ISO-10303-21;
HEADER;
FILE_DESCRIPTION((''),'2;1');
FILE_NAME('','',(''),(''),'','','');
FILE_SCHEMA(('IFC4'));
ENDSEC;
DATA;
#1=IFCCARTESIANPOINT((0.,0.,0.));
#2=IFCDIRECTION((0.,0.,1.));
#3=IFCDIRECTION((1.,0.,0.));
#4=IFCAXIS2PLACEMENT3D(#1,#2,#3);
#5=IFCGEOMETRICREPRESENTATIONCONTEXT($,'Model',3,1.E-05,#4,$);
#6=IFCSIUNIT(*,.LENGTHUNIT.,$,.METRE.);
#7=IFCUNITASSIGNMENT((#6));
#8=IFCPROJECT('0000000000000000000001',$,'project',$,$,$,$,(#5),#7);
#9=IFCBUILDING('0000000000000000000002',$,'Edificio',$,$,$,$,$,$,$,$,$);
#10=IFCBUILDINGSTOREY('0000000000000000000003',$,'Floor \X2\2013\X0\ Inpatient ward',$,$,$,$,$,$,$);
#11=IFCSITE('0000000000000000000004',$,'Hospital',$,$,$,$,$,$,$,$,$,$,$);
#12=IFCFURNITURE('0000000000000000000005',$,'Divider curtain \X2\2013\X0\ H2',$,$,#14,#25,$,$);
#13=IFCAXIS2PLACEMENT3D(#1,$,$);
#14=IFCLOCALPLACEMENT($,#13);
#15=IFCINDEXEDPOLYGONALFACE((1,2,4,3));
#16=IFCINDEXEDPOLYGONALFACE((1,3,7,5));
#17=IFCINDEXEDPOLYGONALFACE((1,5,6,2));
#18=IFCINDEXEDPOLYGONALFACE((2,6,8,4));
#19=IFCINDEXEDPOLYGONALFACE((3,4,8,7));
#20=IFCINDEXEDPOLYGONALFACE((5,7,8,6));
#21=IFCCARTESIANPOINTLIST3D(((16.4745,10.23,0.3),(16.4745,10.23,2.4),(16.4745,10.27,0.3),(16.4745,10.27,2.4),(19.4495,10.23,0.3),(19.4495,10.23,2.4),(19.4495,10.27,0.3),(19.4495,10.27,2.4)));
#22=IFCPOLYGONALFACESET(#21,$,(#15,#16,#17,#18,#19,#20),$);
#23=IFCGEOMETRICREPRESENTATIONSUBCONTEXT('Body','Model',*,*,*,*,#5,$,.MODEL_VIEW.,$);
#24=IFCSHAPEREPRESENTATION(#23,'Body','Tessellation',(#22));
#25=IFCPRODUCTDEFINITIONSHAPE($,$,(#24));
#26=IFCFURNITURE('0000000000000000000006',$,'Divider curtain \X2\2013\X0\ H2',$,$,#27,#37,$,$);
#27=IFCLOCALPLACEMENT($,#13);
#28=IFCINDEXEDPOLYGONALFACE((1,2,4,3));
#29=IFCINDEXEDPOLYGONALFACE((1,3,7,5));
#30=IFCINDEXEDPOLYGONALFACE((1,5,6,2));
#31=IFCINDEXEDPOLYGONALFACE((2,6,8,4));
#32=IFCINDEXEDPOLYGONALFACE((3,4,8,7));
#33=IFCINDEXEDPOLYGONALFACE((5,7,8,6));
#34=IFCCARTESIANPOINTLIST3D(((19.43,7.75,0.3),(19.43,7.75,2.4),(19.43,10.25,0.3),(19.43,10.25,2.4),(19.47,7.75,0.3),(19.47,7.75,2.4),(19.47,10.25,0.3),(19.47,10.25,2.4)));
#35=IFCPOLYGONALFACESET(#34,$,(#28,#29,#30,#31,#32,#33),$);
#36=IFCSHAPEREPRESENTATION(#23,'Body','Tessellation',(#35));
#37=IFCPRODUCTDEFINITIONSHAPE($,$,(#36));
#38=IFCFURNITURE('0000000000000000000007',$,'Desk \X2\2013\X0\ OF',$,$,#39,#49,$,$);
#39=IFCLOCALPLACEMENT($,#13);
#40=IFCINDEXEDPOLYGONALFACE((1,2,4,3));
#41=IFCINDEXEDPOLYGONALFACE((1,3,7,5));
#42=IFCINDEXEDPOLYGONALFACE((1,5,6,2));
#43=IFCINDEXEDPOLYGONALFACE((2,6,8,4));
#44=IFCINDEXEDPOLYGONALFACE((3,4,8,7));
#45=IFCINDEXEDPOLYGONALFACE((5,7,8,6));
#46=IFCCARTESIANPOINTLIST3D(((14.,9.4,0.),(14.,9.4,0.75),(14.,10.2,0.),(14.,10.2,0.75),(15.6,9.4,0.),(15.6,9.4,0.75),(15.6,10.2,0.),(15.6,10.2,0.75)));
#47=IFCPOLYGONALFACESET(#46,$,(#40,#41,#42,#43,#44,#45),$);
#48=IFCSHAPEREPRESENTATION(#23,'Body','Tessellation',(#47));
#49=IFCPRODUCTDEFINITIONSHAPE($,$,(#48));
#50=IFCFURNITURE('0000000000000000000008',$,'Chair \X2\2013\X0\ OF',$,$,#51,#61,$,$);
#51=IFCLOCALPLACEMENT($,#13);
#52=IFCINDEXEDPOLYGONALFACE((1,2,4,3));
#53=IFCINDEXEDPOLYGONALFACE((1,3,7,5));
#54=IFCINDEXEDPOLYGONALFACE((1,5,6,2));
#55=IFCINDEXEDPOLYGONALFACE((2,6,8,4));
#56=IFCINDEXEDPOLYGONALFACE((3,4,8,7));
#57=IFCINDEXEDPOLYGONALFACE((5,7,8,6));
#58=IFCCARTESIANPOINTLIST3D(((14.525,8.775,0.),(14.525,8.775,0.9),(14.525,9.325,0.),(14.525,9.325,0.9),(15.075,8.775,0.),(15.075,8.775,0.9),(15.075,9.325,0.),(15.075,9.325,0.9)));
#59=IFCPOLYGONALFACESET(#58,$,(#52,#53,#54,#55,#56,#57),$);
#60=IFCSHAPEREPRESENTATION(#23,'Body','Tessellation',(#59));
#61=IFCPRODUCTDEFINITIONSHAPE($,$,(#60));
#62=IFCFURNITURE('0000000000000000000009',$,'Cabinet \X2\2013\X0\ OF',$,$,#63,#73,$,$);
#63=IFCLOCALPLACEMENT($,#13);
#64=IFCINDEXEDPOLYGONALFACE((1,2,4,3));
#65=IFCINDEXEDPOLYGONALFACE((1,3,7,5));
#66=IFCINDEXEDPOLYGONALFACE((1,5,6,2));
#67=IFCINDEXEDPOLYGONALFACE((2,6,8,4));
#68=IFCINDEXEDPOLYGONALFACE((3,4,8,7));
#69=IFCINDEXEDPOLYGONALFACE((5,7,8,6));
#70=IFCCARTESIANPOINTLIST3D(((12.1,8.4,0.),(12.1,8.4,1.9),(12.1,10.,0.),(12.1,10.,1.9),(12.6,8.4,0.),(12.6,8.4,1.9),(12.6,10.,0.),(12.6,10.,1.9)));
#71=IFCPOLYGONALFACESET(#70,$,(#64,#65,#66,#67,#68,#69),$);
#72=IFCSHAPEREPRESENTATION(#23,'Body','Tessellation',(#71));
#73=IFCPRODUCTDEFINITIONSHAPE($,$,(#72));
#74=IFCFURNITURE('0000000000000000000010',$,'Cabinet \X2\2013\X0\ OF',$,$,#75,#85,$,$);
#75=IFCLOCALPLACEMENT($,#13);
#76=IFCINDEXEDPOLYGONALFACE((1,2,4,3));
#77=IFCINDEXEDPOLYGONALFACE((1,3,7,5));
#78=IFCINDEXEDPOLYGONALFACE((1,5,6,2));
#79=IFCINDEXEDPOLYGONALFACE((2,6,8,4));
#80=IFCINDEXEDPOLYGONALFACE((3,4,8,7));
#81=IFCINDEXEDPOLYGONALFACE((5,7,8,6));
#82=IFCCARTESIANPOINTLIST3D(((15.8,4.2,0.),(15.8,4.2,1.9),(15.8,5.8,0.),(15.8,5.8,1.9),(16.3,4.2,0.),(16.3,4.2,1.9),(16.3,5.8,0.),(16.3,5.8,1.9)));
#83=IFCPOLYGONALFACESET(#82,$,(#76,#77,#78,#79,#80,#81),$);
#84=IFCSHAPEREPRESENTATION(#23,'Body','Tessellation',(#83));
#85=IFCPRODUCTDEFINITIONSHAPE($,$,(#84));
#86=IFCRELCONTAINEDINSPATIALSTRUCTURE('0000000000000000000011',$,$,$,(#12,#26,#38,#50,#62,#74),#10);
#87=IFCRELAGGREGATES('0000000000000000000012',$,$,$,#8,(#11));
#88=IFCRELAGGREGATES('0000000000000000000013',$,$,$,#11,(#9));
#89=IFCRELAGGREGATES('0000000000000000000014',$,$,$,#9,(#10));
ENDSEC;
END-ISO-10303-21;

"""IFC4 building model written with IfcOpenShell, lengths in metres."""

from ifc_helpers import new_model, si_unit, frame, origin_with_axes, context, subcontext, project, spatial, line, indexed_curve, outline, extrude, element, save


model = new_model("IFC4")

# Units and contexts
model_context = context("Model", 3, precision=1e-05, world=origin_with_axes())
body_context = subcontext(model_context, "Body", "Model", "MODEL_VIEW")
ifc_project = project(units=[si_unit("LENGTHUNIT", "METRE")], contexts=[model_context])

# Site, building, storey
site = spatial("IfcSite", under=ifc_project, Name="Hospital")
building = spatial("IfcBuilding", under=site, Name="Edificio")
storey = spatial("IfcBuildingStorey", under=building, Name="Floor – Inpatient ward")

# Furniture
element("IfcFurniture", 1, inside=storey, Name="Divider curtain – H2", context=body_context, shape_type="SweptSolid", body=[
    extrude(outline(indexed_curve([(0.0, 0.0), (2.975, 0.0), (2.975, 0.04), (0.0, 0.04)], segments=[line(1, 2, 3, 4, 1)])), frame((16.4745, 10.23, 0.3), z_axis=(0.0, 0.0, 1.0), x_axis=(1.0, 0.0, 0.0)), (0.0, 0.0, 1.0), 2.1),
])
element("IfcFurniture", 2, inside=storey, Name="Divider curtain – H2", context=body_context, shape_type="SweptSolid", body=[
    extrude(outline(indexed_curve([(0.0, 0.0), (0.04, 0.0), (0.04, 2.5), (0.0, 2.5)], segments=[line(1, 2, 3, 4, 1)])), frame((19.43, 7.75, 0.3), z_axis=(0.0, 0.0, 1.0), x_axis=(1.0, 0.0, 0.0)), (0.0, 0.0, 1.0), 2.1),
])
element("IfcFurniture", 3, inside=storey, Name="Desk – OF", context=body_context, shape_type="SweptSolid", body=[
    extrude(outline(indexed_curve([(0.0, 0.0), (1.6, 0.0), (1.6, 0.8), (0.0, 0.8)], segments=[line(1, 2, 3, 4, 1)])), frame((14.0, 9.4, 0.0), z_axis=(0.0, 0.0, 1.0), x_axis=(1.0, 0.0, 0.0)), (0.0, 0.0, 1.0), 0.75),
])
element("IfcFurniture", 4, inside=storey, Name="Chair – OF", context=body_context, shape_type="SweptSolid", body=[
    extrude(outline(indexed_curve([(0.0, 0.0), (0.55, 0.0), (0.55, 0.55), (0.0, 0.55)], segments=[line(1, 2, 3, 4, 1)])), frame((14.525, 8.775, 0.0), z_axis=(0.0, 0.0, 1.0), x_axis=(1.0, 0.0, 0.0)), (0.0, 0.0, 1.0), 0.9),
])
element("IfcFurniture", 5, inside=storey, Name="Cabinet – OF", context=body_context, shape_type="SweptSolid", body=[
    extrude(outline(indexed_curve([(0.0, 0.0), (0.5, 0.0), (0.5, 1.6), (0.0, 1.6)], segments=[line(1, 2, 3, 4, 1)])), frame((12.1, 8.4, 0.0), z_axis=(0.0, 0.0, 1.0), x_axis=(1.0, 0.0, 0.0)), (0.0, 0.0, 1.0), 1.9),
])
element("IfcFurniture", 6, inside=storey, Name="Cabinet – OF", context=body_context, shape_type="SweptSolid", body=[
    extrude(outline(indexed_curve([(0.0, 0.0), (0.5, 0.0), (0.5, 1.6), (0.0, 1.6)], segments=[line(1, 2, 3, 4, 1)])), frame((15.8, 4.2, 0.0), z_axis=(0.0, 0.0, 1.0), x_axis=(1.0, 0.0, 0.0)), (0.0, 0.0, 1.0), 1.9),
])

save(model, "model.ifc")
